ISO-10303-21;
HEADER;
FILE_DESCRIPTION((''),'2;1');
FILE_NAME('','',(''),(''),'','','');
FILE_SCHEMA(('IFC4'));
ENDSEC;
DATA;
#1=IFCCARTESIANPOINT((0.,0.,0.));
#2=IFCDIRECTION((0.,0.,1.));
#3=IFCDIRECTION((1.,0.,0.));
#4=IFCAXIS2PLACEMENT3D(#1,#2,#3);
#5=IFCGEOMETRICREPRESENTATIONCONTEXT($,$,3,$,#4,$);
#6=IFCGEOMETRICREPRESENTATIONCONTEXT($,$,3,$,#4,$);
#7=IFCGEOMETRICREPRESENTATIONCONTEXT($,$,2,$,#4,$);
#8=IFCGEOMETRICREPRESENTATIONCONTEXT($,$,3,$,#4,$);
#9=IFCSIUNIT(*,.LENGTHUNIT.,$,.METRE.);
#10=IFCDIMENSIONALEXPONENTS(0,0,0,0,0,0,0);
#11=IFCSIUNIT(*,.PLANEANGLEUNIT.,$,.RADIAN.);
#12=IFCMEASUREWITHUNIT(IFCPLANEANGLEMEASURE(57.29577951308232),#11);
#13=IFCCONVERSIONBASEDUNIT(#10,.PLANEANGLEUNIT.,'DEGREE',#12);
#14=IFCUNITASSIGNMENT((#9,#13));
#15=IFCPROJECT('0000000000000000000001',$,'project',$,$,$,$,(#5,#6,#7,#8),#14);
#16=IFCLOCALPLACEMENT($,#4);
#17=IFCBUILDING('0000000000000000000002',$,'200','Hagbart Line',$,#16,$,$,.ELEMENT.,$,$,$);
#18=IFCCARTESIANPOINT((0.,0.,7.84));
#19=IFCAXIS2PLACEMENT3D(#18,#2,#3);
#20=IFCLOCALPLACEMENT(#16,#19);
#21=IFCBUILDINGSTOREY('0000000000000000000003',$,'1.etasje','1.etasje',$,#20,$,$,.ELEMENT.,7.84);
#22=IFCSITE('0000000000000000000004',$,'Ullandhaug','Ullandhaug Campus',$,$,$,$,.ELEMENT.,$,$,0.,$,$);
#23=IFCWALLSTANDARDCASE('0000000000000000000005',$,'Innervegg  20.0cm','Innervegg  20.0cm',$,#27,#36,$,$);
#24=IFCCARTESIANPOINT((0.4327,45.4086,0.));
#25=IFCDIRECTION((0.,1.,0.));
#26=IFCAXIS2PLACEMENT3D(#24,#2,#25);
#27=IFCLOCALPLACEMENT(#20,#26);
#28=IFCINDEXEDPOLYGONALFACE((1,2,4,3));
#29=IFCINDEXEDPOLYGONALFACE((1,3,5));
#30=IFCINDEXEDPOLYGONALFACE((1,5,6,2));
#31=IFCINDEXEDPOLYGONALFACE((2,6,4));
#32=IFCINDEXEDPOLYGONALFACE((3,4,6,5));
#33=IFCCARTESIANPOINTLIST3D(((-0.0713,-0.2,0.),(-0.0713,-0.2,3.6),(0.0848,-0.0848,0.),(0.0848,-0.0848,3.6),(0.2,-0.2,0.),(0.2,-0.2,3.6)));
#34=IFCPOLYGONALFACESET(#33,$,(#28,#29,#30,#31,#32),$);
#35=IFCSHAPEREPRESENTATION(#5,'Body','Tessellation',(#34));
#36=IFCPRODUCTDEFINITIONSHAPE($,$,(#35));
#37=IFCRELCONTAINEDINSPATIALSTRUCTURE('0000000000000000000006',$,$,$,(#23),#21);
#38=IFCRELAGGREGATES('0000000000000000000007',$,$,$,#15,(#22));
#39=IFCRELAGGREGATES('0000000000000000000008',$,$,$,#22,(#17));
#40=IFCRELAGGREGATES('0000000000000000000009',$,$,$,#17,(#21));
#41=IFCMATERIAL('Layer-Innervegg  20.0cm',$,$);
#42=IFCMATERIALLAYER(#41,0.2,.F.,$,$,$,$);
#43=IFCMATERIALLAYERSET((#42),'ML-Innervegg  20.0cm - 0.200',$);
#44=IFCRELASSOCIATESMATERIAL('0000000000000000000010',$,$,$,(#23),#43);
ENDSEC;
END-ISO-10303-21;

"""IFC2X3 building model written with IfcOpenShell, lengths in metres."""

from ifc_helpers import new_model, entity, si_unit, converted_unit, frame, origin_with_axes, place, context, project, spatial, polyline, outline, extrude, material, layer, layer_set, layer_usage, element, save


model = new_model("IFC2X3")

# Units and contexts
context_of_model_1 = context(None, 3, world=origin_with_axes())
context_of_model_2 = context(None, 3, world=origin_with_axes())
context_of_model_3 = context(None, 2, world=origin_with_axes())
context_of_model_4 = context(None, 3, world=origin_with_axes())
ifc_project = project(units=[si_unit("LENGTHUNIT", "METRE"), converted_unit("PLANEANGLEUNIT", "DEGREE", entity("IfcPlaneAngleMeasure", 57.29577951308232), si_unit("PLANEANGLEUNIT", "RADIAN"), dimensions=[0, 0, 0, 0, 0, 0, 0])], contexts=[context_of_model_1, context_of_model_2, context_of_model_3, context_of_model_4])

# Site, building, storey
site = spatial("IfcSite", under=ifc_project, Name="Ullandhaug", Description="Ullandhaug Campus", CompositionType="ELEMENT", RefElevation=0.0)
building_placement = place(None, origin_with_axes())
building = spatial("IfcBuilding", under=site, at=building_placement, Name="200", Description="Hagbart Line", CompositionType="ELEMENT")
storey_placement = place(building_placement, frame((0.0, 0.0, 7.84), z_axis=(0.0, 0.0, 1.0), x_axis=(1.0, 0.0, 0.0)))
storey = spatial("IfcBuildingStorey", under=building, at=storey_placement, Name="1.etasje", Description="1.etasje", CompositionType="ELEMENT", Elevation=7.84)

# Shared definitions
ifc_material_1 = material(Name="Layer-Innervegg  20.0cm")
ifc_layer_1 = layer(ifc_material_1, 0.2, ventilated=False)
ifc_layer_set_1 = layer_set([ifc_layer_1], Name="ML-Innervegg  20.0cm - 0.200")
ifc_layer_usage_1 = layer_usage(ifc_layer_set_1, "AXIS2", "POSITIVE", 0.0)

# Wall
wall_1_placement = place(storey_placement, frame((0.4327, 45.4086, 0.0), z_axis=(0.0, 0.0, 1.0), x_axis=(0.0, 1.0, 0.0)))
element("IfcWallStandardCase", 1, at=wall_1_placement, inside=storey, material=ifc_layer_usage_1, Name="Innervegg  20.0cm", Description="Innervegg  20.0cm", context=context_of_model_1, shape_type="SweptSolid", body=[
    extrude(outline(polyline([(0.0, 0.0), (0.1999, 0.0), (-0.0713, 0.2), (0.2, 0.2), (0.0, 0.0)])), frame((0.0, 0.0, 0.0), z_axis=(0.0, 0.0, -1.0), x_axis=(1.0, 0.0, 0.0)), (0.0, 0.0, -1.0), 3.6),
])

save(model, "model.ifc")
